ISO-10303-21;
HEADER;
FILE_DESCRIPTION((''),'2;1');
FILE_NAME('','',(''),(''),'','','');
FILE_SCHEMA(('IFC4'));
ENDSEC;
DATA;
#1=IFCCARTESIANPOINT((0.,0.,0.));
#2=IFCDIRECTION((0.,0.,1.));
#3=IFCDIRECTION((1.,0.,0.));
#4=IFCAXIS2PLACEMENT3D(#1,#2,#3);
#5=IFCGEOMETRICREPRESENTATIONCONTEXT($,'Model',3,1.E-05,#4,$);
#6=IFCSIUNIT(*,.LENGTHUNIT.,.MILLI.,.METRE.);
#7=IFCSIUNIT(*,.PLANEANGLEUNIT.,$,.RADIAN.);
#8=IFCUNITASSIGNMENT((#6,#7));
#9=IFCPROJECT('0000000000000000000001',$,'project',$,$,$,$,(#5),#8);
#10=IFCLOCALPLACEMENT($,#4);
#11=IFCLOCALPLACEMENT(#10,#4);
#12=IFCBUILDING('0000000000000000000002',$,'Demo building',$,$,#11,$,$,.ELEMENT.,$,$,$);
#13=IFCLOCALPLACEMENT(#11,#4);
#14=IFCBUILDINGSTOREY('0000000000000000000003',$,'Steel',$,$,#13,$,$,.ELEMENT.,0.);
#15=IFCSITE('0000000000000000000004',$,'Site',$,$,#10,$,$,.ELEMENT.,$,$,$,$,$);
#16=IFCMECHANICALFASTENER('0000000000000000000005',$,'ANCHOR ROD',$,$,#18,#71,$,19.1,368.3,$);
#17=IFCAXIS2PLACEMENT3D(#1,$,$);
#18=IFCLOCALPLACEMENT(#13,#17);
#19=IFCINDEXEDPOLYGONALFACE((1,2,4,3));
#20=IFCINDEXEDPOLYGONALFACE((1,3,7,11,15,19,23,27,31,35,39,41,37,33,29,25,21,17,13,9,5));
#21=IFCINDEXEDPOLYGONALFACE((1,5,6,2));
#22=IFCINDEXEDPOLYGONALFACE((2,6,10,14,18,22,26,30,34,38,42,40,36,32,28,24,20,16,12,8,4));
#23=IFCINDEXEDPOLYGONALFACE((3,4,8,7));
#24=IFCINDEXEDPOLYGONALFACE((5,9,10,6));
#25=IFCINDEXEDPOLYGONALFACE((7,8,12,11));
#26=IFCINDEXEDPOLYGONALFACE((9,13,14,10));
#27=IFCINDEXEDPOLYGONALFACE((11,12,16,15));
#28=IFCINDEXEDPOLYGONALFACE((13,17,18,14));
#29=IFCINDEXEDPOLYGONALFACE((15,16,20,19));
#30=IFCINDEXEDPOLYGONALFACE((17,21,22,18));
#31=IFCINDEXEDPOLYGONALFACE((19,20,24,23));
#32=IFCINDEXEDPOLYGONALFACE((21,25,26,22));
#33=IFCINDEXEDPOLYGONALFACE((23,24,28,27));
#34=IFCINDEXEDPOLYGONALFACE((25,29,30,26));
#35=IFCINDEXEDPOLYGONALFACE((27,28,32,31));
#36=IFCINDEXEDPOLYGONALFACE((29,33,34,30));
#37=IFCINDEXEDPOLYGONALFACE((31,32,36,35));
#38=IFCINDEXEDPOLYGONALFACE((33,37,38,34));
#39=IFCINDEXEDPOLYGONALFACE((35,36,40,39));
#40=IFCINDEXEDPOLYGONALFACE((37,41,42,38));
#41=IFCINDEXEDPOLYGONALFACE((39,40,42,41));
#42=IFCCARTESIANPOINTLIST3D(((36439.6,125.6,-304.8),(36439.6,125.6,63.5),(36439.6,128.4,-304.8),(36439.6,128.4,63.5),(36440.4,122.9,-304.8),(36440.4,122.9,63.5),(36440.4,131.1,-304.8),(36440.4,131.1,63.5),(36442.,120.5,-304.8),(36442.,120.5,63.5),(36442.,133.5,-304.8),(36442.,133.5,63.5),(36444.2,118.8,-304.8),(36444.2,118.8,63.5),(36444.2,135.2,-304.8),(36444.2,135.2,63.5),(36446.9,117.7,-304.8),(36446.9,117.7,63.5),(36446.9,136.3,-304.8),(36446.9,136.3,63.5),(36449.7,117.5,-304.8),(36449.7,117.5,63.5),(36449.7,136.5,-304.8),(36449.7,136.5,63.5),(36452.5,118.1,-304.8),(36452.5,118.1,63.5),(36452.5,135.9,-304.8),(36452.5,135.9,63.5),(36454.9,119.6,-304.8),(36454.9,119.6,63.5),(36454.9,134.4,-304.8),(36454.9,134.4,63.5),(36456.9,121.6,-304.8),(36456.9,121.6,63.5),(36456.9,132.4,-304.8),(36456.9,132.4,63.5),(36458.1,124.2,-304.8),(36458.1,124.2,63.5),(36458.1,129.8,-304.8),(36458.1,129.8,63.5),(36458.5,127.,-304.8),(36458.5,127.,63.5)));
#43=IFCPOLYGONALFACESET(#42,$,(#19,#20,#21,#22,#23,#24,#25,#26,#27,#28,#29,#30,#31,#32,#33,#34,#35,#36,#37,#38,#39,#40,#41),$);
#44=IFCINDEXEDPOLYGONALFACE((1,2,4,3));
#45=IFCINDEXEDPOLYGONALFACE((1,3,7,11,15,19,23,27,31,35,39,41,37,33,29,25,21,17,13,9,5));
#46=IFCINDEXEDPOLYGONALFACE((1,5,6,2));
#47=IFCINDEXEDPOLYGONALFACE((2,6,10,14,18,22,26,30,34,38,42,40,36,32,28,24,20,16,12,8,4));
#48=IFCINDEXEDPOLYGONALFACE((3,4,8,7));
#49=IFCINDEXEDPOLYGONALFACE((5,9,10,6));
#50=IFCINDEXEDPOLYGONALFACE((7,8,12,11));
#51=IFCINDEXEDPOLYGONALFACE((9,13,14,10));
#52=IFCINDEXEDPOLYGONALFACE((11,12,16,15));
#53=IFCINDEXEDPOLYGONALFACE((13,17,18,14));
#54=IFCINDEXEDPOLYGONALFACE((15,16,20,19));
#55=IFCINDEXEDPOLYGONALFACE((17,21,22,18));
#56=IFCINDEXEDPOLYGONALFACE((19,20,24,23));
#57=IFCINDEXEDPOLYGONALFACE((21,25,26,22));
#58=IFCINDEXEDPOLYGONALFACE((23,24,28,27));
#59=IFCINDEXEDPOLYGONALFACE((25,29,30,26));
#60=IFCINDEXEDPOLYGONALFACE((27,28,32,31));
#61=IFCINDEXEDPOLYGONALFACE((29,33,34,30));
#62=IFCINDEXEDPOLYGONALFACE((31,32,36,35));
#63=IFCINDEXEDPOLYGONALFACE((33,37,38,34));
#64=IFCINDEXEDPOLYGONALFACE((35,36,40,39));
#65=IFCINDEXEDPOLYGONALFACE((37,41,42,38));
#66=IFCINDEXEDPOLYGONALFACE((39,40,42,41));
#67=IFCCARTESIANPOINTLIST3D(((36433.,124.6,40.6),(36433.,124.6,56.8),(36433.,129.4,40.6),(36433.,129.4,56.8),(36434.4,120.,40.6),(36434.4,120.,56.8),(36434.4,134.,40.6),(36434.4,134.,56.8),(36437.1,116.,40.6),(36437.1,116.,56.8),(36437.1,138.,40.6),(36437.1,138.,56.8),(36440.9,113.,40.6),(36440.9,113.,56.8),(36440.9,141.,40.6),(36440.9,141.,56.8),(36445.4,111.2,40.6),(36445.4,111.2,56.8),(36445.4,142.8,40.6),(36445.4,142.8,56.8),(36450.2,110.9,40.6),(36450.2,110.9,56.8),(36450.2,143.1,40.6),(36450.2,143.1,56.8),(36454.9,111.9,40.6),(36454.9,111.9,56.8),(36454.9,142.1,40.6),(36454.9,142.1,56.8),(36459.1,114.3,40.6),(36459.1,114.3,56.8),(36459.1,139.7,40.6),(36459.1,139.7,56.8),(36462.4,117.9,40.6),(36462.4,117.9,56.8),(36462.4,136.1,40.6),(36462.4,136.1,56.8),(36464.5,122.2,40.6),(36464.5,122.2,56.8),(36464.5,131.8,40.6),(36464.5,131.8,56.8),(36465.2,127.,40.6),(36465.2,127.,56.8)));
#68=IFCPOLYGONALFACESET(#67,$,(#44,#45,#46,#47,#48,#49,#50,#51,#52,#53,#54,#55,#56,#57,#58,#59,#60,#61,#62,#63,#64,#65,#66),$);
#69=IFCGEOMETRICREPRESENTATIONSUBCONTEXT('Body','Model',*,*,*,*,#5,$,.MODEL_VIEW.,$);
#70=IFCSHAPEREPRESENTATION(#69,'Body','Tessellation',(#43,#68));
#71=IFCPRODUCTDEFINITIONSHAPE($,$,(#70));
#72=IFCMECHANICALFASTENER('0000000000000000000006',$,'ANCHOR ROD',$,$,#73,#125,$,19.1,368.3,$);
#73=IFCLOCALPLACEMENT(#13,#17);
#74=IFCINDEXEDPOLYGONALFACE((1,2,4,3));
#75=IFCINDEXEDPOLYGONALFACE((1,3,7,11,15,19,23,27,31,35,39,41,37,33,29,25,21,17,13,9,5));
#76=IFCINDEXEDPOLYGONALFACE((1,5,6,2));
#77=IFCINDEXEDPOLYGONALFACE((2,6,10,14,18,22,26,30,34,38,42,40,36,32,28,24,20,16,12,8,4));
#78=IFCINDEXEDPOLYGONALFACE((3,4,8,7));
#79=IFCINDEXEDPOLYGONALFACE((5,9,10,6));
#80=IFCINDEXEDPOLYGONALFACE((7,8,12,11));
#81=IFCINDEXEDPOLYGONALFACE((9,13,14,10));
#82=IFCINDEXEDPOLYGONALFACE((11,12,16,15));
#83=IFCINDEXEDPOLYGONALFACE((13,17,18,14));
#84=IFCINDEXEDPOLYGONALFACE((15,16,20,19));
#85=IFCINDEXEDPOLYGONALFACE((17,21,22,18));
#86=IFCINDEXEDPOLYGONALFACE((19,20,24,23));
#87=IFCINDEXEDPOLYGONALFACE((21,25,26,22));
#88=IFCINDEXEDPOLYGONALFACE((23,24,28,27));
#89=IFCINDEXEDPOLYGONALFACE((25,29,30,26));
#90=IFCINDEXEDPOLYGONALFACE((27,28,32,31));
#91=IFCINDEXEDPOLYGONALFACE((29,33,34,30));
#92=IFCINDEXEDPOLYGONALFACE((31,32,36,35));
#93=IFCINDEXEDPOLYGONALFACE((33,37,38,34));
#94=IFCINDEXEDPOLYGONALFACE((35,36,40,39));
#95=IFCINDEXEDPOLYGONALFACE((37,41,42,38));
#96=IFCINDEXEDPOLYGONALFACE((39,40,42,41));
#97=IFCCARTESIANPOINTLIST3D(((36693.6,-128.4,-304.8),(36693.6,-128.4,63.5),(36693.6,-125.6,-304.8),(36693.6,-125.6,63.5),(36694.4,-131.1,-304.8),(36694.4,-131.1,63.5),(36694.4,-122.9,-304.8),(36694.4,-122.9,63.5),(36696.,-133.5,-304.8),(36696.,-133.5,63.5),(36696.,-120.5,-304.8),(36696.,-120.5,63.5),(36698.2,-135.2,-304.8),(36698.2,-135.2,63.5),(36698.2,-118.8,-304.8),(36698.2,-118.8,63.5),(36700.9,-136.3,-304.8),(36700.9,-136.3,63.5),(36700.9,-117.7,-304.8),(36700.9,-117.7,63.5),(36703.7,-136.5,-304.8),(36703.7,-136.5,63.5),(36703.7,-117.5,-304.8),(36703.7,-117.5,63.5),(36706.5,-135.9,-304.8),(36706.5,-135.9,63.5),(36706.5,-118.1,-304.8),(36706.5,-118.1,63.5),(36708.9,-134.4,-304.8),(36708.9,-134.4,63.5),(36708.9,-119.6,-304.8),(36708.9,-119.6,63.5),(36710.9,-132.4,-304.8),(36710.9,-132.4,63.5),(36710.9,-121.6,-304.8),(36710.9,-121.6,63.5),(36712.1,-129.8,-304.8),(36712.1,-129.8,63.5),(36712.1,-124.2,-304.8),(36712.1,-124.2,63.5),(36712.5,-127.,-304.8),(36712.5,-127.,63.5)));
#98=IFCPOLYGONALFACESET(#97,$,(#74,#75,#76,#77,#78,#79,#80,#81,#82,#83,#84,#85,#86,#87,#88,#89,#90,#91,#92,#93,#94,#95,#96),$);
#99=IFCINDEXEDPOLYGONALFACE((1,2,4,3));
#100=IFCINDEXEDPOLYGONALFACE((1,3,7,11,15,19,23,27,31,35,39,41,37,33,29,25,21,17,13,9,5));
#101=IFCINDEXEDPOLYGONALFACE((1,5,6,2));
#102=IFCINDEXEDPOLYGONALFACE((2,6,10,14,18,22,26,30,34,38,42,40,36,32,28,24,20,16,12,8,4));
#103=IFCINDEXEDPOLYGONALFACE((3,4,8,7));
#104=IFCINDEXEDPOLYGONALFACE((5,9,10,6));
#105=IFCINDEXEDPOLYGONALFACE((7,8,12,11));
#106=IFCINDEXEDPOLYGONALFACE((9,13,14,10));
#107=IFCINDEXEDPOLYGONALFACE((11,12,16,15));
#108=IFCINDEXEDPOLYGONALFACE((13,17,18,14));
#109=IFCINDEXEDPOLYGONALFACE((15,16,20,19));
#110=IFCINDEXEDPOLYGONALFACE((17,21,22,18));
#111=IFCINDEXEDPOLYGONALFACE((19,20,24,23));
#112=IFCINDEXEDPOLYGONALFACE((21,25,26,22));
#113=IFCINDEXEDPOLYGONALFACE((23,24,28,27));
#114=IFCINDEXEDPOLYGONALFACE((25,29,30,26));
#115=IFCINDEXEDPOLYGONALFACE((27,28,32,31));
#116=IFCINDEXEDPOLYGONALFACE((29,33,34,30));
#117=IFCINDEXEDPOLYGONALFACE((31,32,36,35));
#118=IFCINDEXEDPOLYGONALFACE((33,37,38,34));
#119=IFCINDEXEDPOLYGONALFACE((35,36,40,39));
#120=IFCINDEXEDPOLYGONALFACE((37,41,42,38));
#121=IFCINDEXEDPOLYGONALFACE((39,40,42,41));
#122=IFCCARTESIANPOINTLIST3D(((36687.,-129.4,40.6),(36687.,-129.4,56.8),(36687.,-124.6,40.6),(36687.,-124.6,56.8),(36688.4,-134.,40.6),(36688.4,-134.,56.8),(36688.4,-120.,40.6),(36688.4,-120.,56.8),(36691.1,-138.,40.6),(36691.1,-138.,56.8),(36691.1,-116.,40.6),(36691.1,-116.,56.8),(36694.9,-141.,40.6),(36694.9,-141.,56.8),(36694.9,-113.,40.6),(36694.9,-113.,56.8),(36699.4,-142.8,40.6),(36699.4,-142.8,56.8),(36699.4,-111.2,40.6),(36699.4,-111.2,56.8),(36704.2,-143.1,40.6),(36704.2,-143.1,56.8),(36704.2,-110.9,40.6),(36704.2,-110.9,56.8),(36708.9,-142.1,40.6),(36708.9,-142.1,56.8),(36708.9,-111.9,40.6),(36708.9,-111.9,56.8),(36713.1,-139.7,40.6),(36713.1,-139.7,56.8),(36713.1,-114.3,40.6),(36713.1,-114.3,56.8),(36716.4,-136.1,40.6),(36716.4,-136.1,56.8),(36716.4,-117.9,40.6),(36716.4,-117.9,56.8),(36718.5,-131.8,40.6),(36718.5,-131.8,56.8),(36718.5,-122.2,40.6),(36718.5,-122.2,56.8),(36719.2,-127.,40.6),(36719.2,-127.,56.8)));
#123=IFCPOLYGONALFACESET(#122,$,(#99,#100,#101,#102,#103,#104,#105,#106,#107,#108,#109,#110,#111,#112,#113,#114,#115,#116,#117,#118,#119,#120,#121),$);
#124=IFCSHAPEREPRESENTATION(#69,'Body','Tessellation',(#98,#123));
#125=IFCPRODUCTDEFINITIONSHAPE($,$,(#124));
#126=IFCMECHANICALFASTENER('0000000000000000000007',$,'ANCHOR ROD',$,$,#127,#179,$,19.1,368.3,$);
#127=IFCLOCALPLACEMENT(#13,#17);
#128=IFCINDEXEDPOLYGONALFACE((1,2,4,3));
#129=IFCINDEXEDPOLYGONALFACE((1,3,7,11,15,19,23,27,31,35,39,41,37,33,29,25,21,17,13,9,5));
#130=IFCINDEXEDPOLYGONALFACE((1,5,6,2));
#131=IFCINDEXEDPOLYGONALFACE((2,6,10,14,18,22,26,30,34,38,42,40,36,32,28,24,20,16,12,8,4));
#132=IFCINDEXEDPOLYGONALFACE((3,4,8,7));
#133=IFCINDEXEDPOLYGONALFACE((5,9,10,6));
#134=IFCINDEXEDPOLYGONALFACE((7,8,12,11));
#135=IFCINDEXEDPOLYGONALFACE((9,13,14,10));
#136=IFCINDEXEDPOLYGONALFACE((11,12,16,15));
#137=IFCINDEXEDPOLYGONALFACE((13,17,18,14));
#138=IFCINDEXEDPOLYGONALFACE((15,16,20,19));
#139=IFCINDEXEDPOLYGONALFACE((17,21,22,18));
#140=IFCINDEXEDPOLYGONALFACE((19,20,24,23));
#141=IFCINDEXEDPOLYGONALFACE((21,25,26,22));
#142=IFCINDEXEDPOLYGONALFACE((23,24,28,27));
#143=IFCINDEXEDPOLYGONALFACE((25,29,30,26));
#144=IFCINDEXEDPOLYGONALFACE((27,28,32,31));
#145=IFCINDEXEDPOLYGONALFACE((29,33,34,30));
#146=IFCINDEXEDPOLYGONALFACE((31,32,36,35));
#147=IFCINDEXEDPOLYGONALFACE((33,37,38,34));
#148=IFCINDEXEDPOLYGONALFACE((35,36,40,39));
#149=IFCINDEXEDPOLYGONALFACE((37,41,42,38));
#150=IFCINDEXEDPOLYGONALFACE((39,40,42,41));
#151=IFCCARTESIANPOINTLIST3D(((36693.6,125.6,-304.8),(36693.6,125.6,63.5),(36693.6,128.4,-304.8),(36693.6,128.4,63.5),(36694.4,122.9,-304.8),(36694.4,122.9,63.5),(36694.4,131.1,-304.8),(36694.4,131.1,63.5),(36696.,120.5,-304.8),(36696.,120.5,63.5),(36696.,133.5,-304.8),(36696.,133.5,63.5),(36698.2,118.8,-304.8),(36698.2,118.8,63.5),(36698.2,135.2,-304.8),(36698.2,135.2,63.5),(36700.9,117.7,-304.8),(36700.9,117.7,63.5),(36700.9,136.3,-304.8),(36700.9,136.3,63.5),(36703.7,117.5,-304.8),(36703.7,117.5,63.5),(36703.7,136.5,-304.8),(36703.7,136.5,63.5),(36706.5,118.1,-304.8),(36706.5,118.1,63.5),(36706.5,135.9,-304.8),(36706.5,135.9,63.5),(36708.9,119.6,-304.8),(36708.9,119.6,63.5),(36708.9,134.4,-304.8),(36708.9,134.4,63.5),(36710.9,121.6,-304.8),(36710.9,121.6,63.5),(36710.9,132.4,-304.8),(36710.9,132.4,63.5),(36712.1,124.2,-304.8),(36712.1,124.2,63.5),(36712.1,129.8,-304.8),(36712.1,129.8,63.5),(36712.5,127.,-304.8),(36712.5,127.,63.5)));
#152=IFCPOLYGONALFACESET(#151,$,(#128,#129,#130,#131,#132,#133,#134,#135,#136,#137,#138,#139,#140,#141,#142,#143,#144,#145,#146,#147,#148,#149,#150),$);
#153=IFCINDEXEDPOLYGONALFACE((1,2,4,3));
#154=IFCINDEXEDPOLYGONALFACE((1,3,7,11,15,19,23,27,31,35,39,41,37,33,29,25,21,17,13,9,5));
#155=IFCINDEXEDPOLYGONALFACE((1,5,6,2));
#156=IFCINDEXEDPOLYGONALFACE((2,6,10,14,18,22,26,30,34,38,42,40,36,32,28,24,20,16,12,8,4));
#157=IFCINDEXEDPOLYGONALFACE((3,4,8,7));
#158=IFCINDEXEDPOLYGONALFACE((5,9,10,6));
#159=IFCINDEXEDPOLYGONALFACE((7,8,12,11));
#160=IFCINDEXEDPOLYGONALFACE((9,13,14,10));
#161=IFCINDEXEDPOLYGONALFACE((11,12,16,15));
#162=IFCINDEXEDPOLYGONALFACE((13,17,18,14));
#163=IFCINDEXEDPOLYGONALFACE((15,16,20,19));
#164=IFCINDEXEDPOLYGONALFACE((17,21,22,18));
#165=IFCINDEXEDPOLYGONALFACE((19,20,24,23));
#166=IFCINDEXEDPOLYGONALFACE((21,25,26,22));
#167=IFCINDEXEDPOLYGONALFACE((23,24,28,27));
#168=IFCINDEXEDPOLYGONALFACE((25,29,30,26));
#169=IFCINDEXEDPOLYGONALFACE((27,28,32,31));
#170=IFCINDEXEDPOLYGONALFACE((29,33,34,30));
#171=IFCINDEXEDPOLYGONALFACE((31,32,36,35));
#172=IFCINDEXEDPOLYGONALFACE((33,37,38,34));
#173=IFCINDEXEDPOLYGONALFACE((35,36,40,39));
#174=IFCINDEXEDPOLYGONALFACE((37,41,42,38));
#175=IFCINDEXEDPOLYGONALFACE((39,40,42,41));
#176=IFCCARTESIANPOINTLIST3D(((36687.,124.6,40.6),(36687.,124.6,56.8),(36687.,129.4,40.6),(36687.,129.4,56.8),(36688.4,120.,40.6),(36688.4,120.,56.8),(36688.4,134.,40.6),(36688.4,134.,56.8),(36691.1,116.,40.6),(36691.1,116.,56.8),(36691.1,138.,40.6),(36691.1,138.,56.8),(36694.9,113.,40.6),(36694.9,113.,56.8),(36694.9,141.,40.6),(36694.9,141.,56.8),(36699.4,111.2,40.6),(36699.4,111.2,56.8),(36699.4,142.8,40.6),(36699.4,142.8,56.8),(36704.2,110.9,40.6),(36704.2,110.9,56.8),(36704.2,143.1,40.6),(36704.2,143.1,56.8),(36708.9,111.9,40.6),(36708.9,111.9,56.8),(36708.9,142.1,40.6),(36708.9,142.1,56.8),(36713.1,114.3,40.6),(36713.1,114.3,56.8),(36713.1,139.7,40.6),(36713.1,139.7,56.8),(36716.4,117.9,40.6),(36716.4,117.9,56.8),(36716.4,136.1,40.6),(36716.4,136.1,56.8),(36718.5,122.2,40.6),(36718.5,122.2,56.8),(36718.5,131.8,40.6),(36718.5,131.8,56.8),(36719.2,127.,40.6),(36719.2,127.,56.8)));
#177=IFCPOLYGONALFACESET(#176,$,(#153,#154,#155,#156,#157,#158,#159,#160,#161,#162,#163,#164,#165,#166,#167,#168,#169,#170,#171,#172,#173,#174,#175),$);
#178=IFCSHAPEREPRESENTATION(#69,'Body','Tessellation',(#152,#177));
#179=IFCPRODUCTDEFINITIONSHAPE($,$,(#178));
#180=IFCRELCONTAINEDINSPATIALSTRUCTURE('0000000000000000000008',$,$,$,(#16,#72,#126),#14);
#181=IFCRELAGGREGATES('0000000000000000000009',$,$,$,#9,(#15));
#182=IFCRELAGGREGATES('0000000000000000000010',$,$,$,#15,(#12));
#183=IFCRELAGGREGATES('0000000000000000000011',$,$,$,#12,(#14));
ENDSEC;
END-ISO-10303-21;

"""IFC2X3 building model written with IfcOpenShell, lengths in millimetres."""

from ifc_helpers import new_model, si_unit, frame, origin, origin_with_axes, origin_2d, place, context, subcontext, project, spatial, circle, extrude, element, save


model = new_model("IFC2X3")

# Units and contexts
model_context = context("Model", 3, precision=1e-05, world=origin_with_axes())
body_context = subcontext(model_context, "Body", "Model", "MODEL_VIEW")
ifc_project = project(units=[si_unit("LENGTHUNIT", "METRE", prefix="MILLI"), si_unit("PLANEANGLEUNIT", "RADIAN")], contexts=[model_context])

# Site, building, storey
site_placement = place(None, origin_with_axes())
site = spatial("IfcSite", under=ifc_project, at=site_placement, Name="Site", CompositionType="ELEMENT")
building_placement = place(site_placement, origin_with_axes())
building = spatial("IfcBuilding", under=site, at=building_placement, Name="Demo building", CompositionType="ELEMENT")
placement = place(building_placement, origin_with_axes())
storey = spatial("IfcBuildingStorey", under=building, at=placement, Name="Steel", CompositionType="ELEMENT", Elevation=0.0)

# Mechanical fasteners
for number, where, z_axis, x_axis, name in (
    (1, (36449.0, 127.0, -304.8), (0.0, 0.0, 1.0), (1.0, 0.0, 0.0), "ANCHOR ROD"),
    (2, (36703.0, -127.0, -304.8), (0.0, 0.0, 1.0), (1.0, 0.0, 0.0), "ANCHOR ROD"),
    (3, (36703.0, 127.0, -304.8), (0.0, 0.0, 1.0), (1.0, 0.0, 0.0), "ANCHOR ROD"),
):
    element("IfcMechanicalFastener", number, at=place(placement, frame(where, z_axis=z_axis, x_axis=x_axis)), inside=storey, Name=name, NominalDiameter=19.1, NominalLength=368.3, context=body_context, shape_type="SweptSolid", body=[
        extrude(circle(Radius=9.5, at=origin_2d()), origin(), (0.0, 0.0, 1.0), 368.3),
        extrude(circle(Radius=16.2, at=origin_2d()), frame((0.0, 0.0, 345.4)), (0.0, 0.0, 1.0), 16.2),
    ])

save(model, "model.ifc")
